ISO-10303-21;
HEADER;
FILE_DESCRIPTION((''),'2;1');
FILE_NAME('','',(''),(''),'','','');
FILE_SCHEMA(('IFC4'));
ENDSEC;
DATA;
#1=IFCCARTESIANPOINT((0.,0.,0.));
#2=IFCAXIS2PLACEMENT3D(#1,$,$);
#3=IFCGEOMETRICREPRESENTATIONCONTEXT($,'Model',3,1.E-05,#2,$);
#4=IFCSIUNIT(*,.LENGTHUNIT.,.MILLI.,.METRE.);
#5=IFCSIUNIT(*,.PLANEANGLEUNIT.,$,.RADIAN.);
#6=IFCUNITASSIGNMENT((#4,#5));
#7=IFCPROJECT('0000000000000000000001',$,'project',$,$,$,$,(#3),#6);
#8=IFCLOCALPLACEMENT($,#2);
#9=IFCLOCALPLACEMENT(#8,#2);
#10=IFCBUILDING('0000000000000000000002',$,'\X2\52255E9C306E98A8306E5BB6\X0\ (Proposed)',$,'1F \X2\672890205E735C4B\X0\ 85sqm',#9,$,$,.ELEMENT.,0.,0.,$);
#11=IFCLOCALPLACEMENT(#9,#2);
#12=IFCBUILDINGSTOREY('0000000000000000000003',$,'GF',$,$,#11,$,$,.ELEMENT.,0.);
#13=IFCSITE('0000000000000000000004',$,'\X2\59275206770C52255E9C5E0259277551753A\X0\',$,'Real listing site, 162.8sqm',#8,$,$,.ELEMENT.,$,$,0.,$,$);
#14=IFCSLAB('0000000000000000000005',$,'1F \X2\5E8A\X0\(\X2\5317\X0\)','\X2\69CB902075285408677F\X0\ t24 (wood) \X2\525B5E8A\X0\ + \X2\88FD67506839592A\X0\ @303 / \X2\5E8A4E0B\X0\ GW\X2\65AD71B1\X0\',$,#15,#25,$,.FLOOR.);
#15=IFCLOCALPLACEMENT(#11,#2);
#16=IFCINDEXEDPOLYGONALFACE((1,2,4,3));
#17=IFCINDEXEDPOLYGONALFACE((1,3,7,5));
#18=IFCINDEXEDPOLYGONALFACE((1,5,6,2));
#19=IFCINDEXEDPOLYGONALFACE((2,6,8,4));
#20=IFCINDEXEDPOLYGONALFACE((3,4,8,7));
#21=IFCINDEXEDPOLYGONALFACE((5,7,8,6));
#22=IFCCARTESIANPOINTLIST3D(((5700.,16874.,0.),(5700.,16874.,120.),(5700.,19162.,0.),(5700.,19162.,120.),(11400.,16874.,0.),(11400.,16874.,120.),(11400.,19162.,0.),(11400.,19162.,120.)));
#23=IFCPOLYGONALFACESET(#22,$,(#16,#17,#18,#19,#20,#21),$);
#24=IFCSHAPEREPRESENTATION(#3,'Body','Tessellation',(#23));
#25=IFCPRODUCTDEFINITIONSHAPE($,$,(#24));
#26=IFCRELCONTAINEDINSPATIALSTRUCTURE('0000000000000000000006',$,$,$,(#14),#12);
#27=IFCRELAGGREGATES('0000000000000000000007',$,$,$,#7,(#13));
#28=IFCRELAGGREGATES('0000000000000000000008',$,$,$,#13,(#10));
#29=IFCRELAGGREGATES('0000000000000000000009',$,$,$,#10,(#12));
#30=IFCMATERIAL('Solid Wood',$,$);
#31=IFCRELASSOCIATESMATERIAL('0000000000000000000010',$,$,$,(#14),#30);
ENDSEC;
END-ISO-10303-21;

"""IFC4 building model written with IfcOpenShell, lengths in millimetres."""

from ifc_helpers import new_model, si_unit, frame, frame_2d, origin, place, context, project, spatial, rectangle, extrude, material, element, save


model = new_model("IFC4")

# Units and contexts
model_context = context("Model", 3, precision=1e-05, world=origin())
ifc_project = project(units=[si_unit("LENGTHUNIT", "METRE", prefix="MILLI"), si_unit("PLANEANGLEUNIT", "RADIAN")], contexts=[model_context])

# Site, building, storey
site_placement = place(None, origin())
site = spatial("IfcSite", under=ifc_project, at=site_placement, Name="大分県別府市大畑町", ObjectType="Real listing site, 162.8sqm", CompositionType="ELEMENT", RefElevation=0.0)
building_placement = place(site_placement, origin())
building = spatial("IfcBuilding", under=site, at=building_placement, Name="別府の風の家 (Proposed)", ObjectType="1F 木造平屋 85sqm", CompositionType="ELEMENT", ElevationOfRefHeight=0.0, ElevationOfTerrain=0.0)
storey_placement = place(building_placement, origin())
storey = spatial("IfcBuildingStorey", under=building, at=storey_placement, Name="GF", CompositionType="ELEMENT", Elevation=0.0)

# Slab
ifc_material_1 = material(Name="Solid Wood")
slab_1_placement = place(storey_placement, frame((2850.0, 8437.0, 0.0)))
element("IfcSlab", 1, at=slab_1_placement, inside=storey, material=ifc_material_1, Name="1F 床(北)", Description="構造用合板 t24 (wood) 剛床 + 製材根太 @303 / 床下 GW断熱", PredefinedType="FLOOR", context=model_context, shape_type="SweptSolid", body=[
    extrude(rectangle(XDim=5700.0, YDim=2288.0, at=frame_2d((2850.0, 1144.0))), frame((2850.0, 8437.0, 0.0)), (0.0, 0.0, 1.0), 120.0),
])

save(model, "model.ifc")
